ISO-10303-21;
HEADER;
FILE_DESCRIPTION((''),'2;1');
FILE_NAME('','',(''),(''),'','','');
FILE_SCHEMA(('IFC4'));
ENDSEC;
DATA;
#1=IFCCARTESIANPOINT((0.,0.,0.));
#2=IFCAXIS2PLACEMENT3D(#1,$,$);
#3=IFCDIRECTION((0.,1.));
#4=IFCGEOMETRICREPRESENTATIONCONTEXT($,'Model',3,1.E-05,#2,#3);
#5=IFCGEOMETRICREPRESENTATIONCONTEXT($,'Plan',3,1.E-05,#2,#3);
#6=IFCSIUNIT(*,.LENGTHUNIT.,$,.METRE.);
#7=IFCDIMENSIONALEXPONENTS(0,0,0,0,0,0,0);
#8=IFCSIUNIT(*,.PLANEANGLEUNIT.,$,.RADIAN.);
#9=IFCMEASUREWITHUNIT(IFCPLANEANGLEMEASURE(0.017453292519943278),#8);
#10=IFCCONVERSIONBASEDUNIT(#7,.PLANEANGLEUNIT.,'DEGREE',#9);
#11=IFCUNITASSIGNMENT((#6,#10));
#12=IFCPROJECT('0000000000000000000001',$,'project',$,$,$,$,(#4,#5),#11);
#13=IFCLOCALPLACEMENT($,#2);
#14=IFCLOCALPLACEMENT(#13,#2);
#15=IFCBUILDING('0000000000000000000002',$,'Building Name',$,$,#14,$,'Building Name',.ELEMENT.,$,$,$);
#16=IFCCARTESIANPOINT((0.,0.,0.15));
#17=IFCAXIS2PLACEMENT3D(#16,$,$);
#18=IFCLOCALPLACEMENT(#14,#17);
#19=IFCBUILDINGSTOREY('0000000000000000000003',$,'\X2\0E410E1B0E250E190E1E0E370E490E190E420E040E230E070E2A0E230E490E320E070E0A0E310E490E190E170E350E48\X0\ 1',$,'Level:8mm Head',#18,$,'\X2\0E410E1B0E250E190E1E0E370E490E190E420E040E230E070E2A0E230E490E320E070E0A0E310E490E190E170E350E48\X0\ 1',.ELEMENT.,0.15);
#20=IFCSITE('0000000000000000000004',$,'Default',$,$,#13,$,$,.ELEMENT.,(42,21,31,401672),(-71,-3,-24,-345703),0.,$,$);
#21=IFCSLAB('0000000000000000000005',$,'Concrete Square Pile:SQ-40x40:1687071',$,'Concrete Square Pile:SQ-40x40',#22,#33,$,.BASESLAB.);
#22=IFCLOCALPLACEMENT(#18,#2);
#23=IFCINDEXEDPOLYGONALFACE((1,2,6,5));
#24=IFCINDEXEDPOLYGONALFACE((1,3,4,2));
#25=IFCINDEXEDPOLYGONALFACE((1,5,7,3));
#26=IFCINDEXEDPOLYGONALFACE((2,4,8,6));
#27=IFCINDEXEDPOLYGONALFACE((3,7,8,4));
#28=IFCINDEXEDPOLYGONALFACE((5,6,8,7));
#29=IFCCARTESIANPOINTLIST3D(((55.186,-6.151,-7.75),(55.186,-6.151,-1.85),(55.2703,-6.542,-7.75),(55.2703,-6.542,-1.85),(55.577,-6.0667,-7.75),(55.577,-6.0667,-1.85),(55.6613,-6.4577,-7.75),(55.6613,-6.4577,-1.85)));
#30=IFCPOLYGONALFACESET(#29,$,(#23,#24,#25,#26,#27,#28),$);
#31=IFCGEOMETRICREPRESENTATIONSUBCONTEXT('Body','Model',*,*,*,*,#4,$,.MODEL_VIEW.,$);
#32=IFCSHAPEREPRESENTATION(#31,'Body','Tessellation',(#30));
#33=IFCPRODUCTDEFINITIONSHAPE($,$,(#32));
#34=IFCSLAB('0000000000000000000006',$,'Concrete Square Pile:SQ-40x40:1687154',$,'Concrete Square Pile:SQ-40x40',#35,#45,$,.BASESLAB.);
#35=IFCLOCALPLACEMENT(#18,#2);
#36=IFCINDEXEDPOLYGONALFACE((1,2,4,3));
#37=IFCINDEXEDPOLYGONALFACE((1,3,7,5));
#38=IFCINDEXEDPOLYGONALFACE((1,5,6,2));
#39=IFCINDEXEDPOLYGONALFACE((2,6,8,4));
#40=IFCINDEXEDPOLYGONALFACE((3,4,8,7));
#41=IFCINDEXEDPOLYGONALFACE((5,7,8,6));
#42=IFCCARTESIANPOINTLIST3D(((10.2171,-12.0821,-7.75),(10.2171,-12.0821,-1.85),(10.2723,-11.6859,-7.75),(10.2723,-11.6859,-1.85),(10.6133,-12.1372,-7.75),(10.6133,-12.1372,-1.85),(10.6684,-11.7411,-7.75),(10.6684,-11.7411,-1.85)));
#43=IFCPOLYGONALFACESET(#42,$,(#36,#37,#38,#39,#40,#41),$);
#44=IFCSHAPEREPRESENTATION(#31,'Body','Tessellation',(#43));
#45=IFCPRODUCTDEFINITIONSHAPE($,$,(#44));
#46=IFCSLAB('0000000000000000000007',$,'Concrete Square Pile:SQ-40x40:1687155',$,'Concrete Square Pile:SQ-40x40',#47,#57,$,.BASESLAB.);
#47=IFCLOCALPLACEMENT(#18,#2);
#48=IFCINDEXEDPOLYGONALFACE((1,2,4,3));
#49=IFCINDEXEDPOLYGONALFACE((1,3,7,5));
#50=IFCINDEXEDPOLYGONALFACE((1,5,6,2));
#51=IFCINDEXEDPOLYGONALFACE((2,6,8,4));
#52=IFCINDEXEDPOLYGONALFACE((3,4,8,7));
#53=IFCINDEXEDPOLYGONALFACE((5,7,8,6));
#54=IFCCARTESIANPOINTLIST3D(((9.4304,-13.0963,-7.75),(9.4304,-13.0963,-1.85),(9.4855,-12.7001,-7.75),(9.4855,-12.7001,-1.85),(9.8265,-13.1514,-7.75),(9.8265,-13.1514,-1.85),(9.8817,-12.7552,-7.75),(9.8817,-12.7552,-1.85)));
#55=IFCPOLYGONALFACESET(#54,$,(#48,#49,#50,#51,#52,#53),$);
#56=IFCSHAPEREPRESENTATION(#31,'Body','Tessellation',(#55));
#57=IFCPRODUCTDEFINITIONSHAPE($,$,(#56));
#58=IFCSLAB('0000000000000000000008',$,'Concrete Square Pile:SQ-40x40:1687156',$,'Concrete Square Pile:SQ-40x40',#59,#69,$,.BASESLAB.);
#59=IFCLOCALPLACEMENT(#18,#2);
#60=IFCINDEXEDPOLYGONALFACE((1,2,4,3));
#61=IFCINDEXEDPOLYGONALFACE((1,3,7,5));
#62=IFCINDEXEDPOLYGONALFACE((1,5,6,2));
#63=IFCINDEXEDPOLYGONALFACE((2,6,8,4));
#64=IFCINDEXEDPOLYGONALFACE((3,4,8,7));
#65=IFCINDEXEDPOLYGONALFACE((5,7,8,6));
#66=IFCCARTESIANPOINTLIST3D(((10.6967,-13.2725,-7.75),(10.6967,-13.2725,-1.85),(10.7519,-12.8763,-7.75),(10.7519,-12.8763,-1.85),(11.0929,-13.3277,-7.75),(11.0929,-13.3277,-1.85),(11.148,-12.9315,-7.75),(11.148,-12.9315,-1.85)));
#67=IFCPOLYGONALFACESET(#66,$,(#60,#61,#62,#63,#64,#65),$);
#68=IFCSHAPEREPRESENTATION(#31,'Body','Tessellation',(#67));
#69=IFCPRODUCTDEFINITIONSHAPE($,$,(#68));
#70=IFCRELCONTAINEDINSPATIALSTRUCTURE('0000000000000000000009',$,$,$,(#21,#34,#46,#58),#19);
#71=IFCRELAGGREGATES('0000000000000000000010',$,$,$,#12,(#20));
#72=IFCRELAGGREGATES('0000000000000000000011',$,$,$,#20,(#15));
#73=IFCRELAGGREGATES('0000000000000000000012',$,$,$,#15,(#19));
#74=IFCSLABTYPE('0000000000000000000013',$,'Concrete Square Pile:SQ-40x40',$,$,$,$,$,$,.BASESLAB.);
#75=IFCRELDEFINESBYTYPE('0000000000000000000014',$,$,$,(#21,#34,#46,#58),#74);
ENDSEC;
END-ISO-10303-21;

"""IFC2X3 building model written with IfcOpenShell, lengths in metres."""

from ifc_helpers import new_model, entity, si_unit, converted_unit, direction, frame, frame_2d, origin, origin_2d_with_axis, place, context, subcontext, project, spatial, rectangle, extrude, type_object, element, save


model = new_model("IFC2X3")

# Units and contexts
model_context = context("Model", 3, precision=1e-05, world=origin(), true_north=direction((0.0, 1.0)))
plan_context = context("Plan", 3, precision=1e-05, world=origin(), true_north=direction((0.0, 1.0)))
body_context = subcontext(model_context, "Body", "Model", "MODEL_VIEW")
ifc_project = project(units=[si_unit("LENGTHUNIT", "METRE"), converted_unit("PLANEANGLEUNIT", "DEGREE", entity("IfcPlaneAngleMeasure", 0.017453292519943278), si_unit("PLANEANGLEUNIT", "RADIAN"), dimensions=[0, 0, 0, 0, 0, 0, 0])], contexts=[model_context, plan_context])

# Site, building, storey
site_placement = place(None, origin())
site = spatial("IfcSite", under=ifc_project, at=site_placement, Name="Default", CompositionType="ELEMENT", RefLatitude=(42, 21, 31, 401672), RefLongitude=(-71, -3, -24, -345703), RefElevation=0.0)
building_placement = place(site_placement, origin())
building = spatial("IfcBuilding", under=site, at=building_placement, Name="Building Name", LongName="Building Name", CompositionType="ELEMENT")
storey_placement = place(building_placement, frame((0.0, 0.0, 0.15)))
storey = spatial("IfcBuildingStorey", under=building, at=storey_placement, Name="แปลนพื้นโครงสร้างชั้นที่ 1", ObjectType="Level:8mm Head", LongName="แปลนพื้นโครงสร้างชั้นที่ 1", CompositionType="ELEMENT", Elevation=0.15)

# Slabs
slab_type_1 = type_object("IfcSlabType", Name="Concrete Square Pile:SQ-40x40", PredefinedType="BASESLAB")
slab_1_placement = place(storey_placement, origin())
element("IfcSlab", 1, at=slab_1_placement, inside=storey, type_object=slab_type_1, Name="Concrete Square Pile:SQ-40x40:1687071", ObjectType="Concrete Square Pile:SQ-40x40", PredefinedType="BASESLAB", context=body_context, shape_type="SweptSolid", body=[
    extrude(rectangle(XDim=0.4, YDim=0.4, at=frame_2d((0.0, 0.0), x_axis=(1.0, 0.0))), frame((55.4237, -6.3044, -7.75), z_axis=(0.0, 0.0, 1.0), x_axis=(-0.977547, -0.210717, 0.0)), (0.0, 0.0, 1.0), 5.9),
])
slab_2_placement = place(storey_placement, origin())
element("IfcSlab", 2, at=slab_2_placement, inside=storey, type_object=slab_type_1, Name="Concrete Square Pile:SQ-40x40:1687154", ObjectType="Concrete Square Pile:SQ-40x40", PredefinedType="BASESLAB", context=body_context, shape_type="SweptSolid", body=[
    extrude(rectangle(XDim=0.4, YDim=0.4, at=frame_2d((0.0, 0.0), x_axis=(1.0, 0.0))), frame((10.4428, -11.9116, -7.75), z_axis=(0.0, 0.0, 1.0), x_axis=(-0.990454, 0.137844, 0.0)), (0.0, 0.0, 1.0), 5.9),
])
slab_3_placement = place(storey_placement, origin())
element("IfcSlab", 3, at=slab_3_placement, inside=storey, type_object=slab_type_1, Name="Concrete Square Pile:SQ-40x40:1687155", ObjectType="Concrete Square Pile:SQ-40x40", PredefinedType="BASESLAB", context=body_context, shape_type="SweptSolid", body=[
    extrude(rectangle(XDim=0.4, YDim=0.4, at=frame_2d((0.0, 0.0), x_axis=(1.0, 0.0))), frame((9.656, -12.9258, -7.75), z_axis=(0.0, 0.0, 1.0), x_axis=(-0.990454, 0.137844, 0.0)), (0.0, 0.0, 1.0), 5.9),
])
slab_4_placement = place(storey_placement, origin())
element("IfcSlab", 4, at=slab_4_placement, inside=storey, type_object=slab_type_1, Name="Concrete Square Pile:SQ-40x40:1687156", ObjectType="Concrete Square Pile:SQ-40x40", PredefinedType="BASESLAB", context=body_context, shape_type="SweptSolid", body=[
    extrude(rectangle(XDim=0.4, YDim=0.4, at=origin_2d_with_axis()), frame((10.9224, -13.102, -7.75), z_axis=(0.0, 0.0, 1.0), x_axis=(-0.990454, 0.137844, 0.0)), (0.0, 0.0, 1.0), 5.9),
])

save(model, "model.ifc")
